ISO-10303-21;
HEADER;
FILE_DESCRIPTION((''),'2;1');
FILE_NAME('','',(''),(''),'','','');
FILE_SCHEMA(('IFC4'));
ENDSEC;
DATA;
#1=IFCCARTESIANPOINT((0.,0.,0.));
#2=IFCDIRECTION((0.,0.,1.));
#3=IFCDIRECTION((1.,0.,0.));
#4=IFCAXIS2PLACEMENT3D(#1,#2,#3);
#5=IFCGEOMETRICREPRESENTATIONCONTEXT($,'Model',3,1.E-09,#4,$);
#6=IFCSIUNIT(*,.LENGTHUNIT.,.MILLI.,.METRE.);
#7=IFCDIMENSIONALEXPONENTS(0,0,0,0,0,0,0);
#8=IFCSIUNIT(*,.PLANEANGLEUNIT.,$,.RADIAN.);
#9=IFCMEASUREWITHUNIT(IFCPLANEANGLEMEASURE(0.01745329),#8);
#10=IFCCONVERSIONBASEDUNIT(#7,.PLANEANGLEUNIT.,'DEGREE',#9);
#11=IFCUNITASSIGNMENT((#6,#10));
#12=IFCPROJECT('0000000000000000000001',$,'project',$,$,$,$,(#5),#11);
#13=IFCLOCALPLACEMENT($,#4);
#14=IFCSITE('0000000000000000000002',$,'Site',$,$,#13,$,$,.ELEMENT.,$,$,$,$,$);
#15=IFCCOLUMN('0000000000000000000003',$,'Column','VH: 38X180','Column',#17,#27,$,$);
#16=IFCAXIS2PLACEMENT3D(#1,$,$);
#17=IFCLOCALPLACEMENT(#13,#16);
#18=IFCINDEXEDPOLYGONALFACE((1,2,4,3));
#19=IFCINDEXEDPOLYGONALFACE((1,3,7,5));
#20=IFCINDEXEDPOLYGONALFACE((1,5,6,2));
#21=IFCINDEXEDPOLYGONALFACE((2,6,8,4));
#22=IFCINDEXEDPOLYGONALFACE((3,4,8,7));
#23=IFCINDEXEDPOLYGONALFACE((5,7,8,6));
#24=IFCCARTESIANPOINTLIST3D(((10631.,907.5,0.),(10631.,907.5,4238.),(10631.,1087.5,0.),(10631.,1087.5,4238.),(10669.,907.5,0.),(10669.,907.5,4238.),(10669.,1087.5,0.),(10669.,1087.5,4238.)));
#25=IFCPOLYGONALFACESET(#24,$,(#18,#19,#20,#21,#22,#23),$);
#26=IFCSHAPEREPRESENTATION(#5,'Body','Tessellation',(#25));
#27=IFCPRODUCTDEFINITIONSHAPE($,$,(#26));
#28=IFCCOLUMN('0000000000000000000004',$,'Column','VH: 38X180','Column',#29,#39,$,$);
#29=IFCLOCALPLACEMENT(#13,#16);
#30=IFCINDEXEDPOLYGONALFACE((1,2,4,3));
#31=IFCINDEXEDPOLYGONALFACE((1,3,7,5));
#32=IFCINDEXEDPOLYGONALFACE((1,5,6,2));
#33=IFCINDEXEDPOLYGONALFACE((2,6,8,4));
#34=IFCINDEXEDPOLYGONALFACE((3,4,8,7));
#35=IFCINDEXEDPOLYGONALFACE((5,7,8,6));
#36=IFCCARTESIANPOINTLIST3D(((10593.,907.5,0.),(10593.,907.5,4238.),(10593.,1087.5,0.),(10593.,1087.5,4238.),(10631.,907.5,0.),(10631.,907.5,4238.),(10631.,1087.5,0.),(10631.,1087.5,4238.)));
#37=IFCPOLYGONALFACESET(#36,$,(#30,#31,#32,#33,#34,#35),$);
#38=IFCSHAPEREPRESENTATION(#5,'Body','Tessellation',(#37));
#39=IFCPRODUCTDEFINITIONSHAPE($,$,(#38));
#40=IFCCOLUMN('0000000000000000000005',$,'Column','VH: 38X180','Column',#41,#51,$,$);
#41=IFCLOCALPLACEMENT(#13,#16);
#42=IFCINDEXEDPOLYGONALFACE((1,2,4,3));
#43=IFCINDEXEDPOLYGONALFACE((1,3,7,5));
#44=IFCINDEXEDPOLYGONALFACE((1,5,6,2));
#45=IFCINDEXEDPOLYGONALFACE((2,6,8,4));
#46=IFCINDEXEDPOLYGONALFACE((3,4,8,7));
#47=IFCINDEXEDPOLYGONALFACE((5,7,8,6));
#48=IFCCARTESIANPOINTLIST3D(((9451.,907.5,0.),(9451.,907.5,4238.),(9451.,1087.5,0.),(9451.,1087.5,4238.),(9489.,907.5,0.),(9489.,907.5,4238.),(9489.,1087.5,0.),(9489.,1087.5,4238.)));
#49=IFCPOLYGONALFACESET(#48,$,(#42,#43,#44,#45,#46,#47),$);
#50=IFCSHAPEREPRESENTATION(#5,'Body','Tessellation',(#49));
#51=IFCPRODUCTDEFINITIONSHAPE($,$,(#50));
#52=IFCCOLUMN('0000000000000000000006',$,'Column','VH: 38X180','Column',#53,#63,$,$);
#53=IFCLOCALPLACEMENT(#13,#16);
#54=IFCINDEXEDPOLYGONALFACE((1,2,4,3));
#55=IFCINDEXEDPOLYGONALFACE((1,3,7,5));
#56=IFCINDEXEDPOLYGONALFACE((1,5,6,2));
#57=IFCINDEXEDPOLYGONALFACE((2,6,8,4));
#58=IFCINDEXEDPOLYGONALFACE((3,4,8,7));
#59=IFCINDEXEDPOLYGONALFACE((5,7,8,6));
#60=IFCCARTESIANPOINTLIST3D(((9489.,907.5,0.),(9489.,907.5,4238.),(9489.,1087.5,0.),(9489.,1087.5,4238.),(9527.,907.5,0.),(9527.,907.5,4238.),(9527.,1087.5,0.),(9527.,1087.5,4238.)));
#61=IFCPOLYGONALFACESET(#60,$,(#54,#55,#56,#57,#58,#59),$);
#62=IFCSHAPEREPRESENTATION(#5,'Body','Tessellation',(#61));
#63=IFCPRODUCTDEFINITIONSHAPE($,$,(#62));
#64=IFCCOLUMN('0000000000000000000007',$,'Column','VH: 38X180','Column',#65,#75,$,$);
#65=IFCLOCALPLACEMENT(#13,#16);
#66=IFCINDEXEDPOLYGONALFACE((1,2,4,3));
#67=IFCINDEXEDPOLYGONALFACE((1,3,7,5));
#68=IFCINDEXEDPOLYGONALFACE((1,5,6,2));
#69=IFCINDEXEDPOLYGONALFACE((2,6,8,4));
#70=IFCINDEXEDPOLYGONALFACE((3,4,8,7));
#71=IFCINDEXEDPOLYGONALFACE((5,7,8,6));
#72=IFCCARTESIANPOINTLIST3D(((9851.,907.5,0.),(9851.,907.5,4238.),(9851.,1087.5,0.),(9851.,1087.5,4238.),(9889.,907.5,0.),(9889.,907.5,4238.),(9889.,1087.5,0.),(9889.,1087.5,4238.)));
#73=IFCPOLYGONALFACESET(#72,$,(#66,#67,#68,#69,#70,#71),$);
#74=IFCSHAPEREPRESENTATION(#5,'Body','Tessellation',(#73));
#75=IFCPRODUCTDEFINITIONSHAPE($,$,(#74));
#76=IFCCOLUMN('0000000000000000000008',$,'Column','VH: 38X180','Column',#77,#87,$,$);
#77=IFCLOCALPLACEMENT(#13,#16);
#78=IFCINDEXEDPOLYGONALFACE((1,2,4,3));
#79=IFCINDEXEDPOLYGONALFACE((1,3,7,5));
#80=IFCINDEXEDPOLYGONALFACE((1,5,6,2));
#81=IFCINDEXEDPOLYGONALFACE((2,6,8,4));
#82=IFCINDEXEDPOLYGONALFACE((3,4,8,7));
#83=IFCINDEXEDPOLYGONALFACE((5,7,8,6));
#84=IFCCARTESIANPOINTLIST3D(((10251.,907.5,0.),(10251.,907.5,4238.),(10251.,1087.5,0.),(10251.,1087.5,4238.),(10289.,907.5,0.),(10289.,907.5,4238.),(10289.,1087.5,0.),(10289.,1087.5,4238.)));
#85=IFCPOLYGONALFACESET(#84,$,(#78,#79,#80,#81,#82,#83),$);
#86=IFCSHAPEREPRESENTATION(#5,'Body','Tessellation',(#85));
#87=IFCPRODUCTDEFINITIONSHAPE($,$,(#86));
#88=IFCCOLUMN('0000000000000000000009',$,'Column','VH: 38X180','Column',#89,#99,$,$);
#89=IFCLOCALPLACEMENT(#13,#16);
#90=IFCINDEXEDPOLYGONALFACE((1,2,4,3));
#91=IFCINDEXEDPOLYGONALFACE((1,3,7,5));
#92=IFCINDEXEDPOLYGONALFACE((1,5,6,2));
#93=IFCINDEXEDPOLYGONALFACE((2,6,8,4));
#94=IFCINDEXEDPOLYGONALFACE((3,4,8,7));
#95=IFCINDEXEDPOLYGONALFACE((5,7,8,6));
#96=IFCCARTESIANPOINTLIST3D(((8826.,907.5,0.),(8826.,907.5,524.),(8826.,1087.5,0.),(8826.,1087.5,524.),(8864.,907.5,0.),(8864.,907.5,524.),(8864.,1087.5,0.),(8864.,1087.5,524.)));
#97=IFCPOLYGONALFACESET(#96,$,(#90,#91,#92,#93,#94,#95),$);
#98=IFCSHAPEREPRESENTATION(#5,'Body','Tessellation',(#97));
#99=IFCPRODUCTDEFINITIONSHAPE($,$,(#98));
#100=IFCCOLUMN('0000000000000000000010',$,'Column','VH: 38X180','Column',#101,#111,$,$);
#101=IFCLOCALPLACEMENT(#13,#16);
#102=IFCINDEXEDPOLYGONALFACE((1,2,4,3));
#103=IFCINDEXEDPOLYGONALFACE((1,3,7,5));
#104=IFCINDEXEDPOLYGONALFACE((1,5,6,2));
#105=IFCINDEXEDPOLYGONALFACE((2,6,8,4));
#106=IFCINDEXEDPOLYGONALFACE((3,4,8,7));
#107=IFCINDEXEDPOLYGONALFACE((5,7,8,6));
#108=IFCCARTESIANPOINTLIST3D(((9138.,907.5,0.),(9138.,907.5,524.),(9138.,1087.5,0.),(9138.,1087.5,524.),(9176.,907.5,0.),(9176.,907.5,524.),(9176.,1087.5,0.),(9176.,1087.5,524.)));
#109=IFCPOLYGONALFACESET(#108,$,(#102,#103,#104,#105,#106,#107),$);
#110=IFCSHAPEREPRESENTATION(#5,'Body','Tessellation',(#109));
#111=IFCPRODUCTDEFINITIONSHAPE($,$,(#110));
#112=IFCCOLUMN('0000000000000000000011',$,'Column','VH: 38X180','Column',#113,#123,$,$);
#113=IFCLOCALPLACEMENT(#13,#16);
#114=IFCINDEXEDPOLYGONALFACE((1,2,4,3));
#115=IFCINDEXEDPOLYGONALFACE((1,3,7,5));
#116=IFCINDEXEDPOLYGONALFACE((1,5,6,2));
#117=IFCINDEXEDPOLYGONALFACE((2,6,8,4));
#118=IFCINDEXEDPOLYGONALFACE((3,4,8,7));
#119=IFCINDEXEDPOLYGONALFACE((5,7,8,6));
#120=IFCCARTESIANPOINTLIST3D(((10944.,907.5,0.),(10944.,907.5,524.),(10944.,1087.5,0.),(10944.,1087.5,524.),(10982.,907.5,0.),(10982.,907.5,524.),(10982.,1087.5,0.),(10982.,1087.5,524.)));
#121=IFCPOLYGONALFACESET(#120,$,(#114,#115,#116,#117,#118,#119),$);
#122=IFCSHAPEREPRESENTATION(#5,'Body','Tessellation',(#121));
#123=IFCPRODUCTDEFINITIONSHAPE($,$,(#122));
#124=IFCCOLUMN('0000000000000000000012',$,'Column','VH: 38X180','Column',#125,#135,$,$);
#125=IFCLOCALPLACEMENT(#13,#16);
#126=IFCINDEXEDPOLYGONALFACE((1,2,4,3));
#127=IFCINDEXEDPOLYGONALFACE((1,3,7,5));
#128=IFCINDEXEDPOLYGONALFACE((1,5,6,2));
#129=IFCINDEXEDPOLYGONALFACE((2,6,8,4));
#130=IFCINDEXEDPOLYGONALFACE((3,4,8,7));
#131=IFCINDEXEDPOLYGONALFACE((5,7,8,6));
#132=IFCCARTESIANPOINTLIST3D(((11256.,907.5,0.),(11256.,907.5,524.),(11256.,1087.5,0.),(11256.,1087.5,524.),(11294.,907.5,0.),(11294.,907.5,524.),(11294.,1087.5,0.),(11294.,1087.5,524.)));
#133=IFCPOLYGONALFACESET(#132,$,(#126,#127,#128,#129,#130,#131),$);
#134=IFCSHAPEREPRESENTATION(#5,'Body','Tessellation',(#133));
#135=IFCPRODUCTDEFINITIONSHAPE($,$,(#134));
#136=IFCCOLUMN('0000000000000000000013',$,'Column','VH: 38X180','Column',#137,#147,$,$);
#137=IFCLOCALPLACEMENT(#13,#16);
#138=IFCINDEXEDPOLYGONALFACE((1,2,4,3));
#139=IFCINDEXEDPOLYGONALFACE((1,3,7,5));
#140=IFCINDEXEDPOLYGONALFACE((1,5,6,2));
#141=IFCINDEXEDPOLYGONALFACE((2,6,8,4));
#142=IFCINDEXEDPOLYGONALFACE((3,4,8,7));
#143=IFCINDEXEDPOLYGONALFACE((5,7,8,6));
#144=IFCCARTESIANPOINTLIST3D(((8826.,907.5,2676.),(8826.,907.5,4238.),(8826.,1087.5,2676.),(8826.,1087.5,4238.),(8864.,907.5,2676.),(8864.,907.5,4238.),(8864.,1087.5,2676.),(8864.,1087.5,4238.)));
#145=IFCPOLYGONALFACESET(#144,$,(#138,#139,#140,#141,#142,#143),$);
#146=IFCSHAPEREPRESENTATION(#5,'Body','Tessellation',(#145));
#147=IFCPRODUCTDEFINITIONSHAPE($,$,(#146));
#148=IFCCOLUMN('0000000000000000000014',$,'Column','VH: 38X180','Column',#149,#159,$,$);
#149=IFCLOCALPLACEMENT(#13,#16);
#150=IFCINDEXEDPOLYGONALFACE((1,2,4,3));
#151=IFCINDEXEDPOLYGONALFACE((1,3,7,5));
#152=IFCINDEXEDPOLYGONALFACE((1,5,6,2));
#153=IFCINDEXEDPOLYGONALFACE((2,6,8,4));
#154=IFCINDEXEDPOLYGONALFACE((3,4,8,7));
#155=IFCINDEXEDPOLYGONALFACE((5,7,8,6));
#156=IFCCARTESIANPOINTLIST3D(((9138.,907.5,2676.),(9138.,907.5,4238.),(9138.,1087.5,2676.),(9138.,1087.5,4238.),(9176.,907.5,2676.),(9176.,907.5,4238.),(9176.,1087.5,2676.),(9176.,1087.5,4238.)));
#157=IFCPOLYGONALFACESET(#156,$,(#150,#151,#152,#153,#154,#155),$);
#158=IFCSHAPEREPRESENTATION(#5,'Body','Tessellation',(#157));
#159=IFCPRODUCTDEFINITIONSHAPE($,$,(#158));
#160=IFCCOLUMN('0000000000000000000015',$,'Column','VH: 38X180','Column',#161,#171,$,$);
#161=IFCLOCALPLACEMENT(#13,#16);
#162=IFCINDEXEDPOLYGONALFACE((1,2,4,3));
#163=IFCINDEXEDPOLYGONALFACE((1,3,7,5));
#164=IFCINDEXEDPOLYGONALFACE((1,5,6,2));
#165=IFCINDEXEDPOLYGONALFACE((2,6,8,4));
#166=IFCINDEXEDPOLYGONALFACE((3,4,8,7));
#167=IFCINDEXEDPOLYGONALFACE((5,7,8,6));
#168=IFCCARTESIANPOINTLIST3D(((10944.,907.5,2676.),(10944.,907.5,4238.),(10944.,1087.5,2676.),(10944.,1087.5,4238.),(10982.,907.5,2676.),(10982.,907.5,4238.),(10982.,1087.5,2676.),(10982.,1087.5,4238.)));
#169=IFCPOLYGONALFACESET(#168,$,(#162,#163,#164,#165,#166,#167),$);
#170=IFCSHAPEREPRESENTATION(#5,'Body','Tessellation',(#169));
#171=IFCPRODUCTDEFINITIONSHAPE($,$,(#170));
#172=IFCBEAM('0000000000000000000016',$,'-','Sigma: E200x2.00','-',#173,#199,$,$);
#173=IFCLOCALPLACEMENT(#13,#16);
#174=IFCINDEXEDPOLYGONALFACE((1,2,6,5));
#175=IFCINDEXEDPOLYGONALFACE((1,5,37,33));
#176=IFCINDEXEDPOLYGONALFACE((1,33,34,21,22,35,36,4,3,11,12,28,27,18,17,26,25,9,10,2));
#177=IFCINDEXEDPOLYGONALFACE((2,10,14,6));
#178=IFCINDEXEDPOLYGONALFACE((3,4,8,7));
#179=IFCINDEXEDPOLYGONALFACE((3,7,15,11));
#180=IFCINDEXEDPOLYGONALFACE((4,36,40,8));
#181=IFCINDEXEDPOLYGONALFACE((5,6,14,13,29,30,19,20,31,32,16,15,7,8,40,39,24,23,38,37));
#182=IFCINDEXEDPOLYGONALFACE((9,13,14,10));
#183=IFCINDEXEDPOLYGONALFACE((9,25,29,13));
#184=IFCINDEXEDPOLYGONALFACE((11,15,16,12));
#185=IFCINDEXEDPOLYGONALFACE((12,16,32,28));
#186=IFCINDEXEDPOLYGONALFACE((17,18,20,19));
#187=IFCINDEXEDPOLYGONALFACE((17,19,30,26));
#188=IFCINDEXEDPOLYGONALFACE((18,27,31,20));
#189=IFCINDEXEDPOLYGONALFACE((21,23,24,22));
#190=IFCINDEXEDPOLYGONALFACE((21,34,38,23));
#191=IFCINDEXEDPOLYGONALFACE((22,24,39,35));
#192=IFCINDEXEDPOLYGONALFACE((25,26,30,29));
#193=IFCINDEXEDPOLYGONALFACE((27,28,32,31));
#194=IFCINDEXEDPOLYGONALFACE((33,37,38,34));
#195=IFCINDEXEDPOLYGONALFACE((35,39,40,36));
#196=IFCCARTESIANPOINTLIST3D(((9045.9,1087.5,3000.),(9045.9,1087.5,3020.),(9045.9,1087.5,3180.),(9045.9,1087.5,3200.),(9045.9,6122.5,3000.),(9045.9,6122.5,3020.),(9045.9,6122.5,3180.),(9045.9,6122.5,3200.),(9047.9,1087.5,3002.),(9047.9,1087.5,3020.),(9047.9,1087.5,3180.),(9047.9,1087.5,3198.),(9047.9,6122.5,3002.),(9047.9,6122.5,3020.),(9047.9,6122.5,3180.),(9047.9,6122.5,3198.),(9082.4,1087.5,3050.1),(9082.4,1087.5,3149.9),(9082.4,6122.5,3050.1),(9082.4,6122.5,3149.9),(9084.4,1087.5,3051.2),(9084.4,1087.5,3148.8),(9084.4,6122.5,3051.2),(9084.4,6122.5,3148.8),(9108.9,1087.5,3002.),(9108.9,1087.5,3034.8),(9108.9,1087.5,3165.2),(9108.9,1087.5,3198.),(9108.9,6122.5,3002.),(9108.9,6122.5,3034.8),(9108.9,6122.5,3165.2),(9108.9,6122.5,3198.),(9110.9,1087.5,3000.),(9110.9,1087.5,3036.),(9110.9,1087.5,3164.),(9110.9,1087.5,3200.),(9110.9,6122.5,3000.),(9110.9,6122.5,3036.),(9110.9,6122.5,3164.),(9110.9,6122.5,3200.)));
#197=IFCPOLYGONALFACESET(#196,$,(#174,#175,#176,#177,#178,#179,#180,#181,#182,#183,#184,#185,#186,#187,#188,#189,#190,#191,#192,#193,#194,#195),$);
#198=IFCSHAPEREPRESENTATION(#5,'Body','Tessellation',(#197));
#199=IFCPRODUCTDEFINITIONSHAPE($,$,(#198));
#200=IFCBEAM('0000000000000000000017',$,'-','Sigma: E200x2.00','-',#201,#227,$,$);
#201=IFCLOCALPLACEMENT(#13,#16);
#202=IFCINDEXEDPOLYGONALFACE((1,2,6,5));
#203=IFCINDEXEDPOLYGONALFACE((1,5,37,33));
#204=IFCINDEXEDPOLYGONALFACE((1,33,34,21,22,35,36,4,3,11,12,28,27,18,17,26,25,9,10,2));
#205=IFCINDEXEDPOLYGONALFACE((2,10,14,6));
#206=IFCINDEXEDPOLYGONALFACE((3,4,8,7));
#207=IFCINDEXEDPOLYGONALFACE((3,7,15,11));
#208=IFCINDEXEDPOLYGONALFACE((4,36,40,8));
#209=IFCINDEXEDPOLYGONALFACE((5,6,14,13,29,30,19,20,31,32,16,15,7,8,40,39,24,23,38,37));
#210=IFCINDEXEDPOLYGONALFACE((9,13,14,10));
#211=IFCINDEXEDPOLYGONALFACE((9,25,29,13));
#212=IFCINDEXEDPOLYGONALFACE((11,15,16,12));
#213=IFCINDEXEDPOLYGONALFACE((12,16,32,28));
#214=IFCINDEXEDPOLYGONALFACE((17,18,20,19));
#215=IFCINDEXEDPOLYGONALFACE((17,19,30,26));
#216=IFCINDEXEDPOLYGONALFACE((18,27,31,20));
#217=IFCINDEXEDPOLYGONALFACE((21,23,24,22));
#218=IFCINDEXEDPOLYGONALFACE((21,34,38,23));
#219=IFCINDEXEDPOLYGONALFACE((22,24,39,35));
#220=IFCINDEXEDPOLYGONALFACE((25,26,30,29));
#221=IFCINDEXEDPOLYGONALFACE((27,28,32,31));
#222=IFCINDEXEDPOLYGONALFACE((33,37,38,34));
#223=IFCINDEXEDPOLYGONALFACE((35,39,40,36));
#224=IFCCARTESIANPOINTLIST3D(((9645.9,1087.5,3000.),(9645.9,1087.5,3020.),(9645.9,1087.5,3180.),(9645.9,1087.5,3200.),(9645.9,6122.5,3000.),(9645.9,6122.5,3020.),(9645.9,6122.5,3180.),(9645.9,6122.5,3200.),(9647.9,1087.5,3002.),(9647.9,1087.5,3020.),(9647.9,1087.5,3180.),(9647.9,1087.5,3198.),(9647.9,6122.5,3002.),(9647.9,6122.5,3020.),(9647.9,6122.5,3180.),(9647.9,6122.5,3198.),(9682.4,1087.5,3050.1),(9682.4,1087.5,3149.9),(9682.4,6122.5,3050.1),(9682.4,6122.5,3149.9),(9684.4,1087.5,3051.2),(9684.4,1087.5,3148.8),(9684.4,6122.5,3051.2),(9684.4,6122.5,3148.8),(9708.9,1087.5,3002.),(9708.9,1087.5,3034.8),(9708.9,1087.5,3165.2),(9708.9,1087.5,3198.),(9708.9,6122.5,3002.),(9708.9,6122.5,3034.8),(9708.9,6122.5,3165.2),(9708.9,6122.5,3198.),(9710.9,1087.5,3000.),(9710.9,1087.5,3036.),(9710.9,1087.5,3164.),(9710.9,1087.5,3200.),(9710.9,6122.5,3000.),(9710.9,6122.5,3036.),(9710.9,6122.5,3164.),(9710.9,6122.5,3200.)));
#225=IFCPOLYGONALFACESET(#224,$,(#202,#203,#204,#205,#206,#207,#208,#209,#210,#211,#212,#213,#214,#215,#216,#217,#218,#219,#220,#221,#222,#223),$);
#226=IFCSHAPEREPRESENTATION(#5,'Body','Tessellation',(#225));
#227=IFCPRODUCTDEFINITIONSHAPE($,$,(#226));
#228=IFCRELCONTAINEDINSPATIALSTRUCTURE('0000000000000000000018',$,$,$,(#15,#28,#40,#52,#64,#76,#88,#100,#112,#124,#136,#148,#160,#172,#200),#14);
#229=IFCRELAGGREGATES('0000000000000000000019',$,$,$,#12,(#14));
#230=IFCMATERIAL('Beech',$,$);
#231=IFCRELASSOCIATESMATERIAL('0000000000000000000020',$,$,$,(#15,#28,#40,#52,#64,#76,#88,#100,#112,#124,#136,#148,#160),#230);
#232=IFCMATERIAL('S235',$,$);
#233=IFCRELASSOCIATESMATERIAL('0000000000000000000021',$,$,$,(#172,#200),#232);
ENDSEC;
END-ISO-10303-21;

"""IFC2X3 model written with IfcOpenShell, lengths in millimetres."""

from ifc_helpers import new_model, entity, si_unit, converted_unit, frame, origin, origin_with_axes, origin_2d, place, context, project, spatial, polyline, rectangle, outline, extrude, material, element, save


model = new_model("IFC2X3")

# Units and contexts
model_context = context("Model", 3, precision=1e-09, world=origin_with_axes())
ifc_project = project(units=[si_unit("LENGTHUNIT", "METRE", prefix="MILLI"), converted_unit("PLANEANGLEUNIT", "DEGREE", entity("IfcPlaneAngleMeasure", 0.01745329), si_unit("PLANEANGLEUNIT", "RADIAN"), dimensions=[0, 0, 0, 0, 0, 0, 0])], contexts=[model_context])

# Site
site_placement = place(None, origin_with_axes())
site = spatial("IfcSite", under=ifc_project, at=site_placement, Name="Site", CompositionType="ELEMENT")

# Columns
ifc_material_1 = material(Name="Beech")
for number, where, z_axis, x_axis, name in (
    (1, (10650.0, 997.5, 0.0), (0.0, 0.0, -1.0), (-1.0, 0.0, 0.0), "Column"),
    (2, (10612.0, 997.5, 0.0), (0.0, 0.0, -1.0), (-1.0, 0.0, 0.0), "Column"),
    (3, (9470.0, 997.5, 0.0), (0.0, 0.0, -1.0), (-1.0, 0.0, 0.0), "Column"),
    (4, (9508.0, 997.5, 0.0), (0.0, 0.0, -1.0), (-1.0, 0.0, 0.0), "Column"),
    (5, (9870.0, 997.5, 0.0), (0.0, 0.0, -1.0), (-1.0, 0.0, 0.0), "Column"),
    (6, (10270.0, 997.5, 0.0), (0.0, 0.0, -1.0), (-1.0, 0.0, 0.0), "Column"),
):
    element("IfcColumn", number, at=place(None, frame(where, z_axis=z_axis, x_axis=x_axis)), inside=site, material=ifc_material_1, Name=name, Description="VH: 38X180", ObjectType="Column", context=model_context, shape_type="SweptSolid", body=[
        extrude(rectangle(XDim=38.0, YDim=180.0, at=origin_2d()), origin(), (0.0, 0.0, -1.0), 4238.0),
    ])
for number, where, z_axis, x_axis, name in (
    (7, (8845.0, 997.5, 0.0), (0.0, 0.0, -1.0), (-1.0, 0.0, 0.0), "Column"),
    (8, (9157.0, 997.5, 0.0), (0.0, 0.0, -1.0), (-1.0, 0.0, 0.0), "Column"),
    (9, (10963.0, 997.5, 0.0), (0.0, 0.0, -1.0), (-1.0, 0.0, 0.0), "Column"),
    (10, (11275.0, 997.5, 0.0), (0.0, 0.0, -1.0), (-1.0, 0.0, 0.0), "Column"),
):
    element("IfcColumn", number, at=place(None, frame(where, z_axis=z_axis, x_axis=x_axis)), inside=site, material=ifc_material_1, Name=name, Description="VH: 38X180", ObjectType="Column", context=model_context, shape_type="SweptSolid", body=[
        extrude(rectangle(XDim=38.0, YDim=180.0, at=origin_2d()), origin(), (0.0, 0.0, -1.0), 524.0),
    ])
column_1_placement = place(None, frame((8845.0, 997.5, 2676.0), z_axis=(0.0, -0.000005, -1.0), x_axis=(-1.0, 0.0, 0.0)))
element("IfcColumn", 11, at=column_1_placement, inside=site, material=ifc_material_1, Name="Column", Description="VH: 38X180", ObjectType="Column", context=model_context, shape_type="SweptSolid", body=[
    extrude(rectangle(XDim=38.0, YDim=180.0, at=origin_2d()), origin(), (0.0, 0.0, -1.0), 1562.0),
])
column_2_placement = place(None, frame((9157.0, 997.5, 2676.0), z_axis=(0.0, 0.0, -1.0), x_axis=(-1.0, 0.0, 0.0)))
element("IfcColumn", 12, at=column_2_placement, inside=site, material=ifc_material_1, Name="Column", Description="VH: 38X180", ObjectType="Column", context=model_context, shape_type="SweptSolid", body=[
    extrude(rectangle(XDim=38.0, YDim=180.0, at=origin_2d()), origin(), (0.0, 0.0, -1.0), 1562.0),
])
column_3_placement = place(None, frame((10963.0, 997.5, 2676.0), z_axis=(0.0, -0.000005, -1.0), x_axis=(-1.0, 0.0, 0.0)))
element("IfcColumn", 13, at=column_3_placement, inside=site, material=ifc_material_1, Name="Column", Description="VH: 38X180", ObjectType="Column", context=model_context, shape_type="SweptSolid", body=[
    extrude(rectangle(XDim=38.0, YDim=180.0, at=origin_2d()), origin(), (0.0, 0.0, -1.0), 1562.0),
])

# Beams
ifc_material_2 = material(Name="S235")
for number, where, z_axis, x_axis, name in (
    (14, (9085.0, 1087.5, 3100.0), (0.0, 1.0, 0.0), (-1.0, 0.0, 0.0), "-"),
    (15, (9685.0, 1087.5, 3100.0), (0.0, 1.0, 0.0), (-1.0, 0.0, 0.0), "-"),
):
    element("IfcBeam", number, at=place(None, frame(where, z_axis=z_axis, x_axis=x_axis)), inside=site, material=ifc_material_2, Name=name, Description="Sigma: E200x2.00", ObjectType="-", context=model_context, shape_type="SweptSolid", body=[
        extrude(outline(polyline([(39.1, -100.0), (39.1, -80.0), (37.1, -80.0), (37.1, -98.0), (-23.9, -98.0), (-23.9, -65.2), (2.6, -49.9), (2.6, 49.9), (-23.9, 65.2), (-23.9, 98.0), (37.1, 98.0), (37.1, 80.0), (39.1, 80.0), (39.1, 100.0), (-25.9, 100.0), (-25.9, 64.0), (0.6, 48.8), (0.6, -48.8), (-25.9, -64.0), (-25.9, -100.0), (39.1, -100.0)])), origin(), (0.0, 0.0, 1.0), 5035.0),
    ])

save(model, "model.ifc")
